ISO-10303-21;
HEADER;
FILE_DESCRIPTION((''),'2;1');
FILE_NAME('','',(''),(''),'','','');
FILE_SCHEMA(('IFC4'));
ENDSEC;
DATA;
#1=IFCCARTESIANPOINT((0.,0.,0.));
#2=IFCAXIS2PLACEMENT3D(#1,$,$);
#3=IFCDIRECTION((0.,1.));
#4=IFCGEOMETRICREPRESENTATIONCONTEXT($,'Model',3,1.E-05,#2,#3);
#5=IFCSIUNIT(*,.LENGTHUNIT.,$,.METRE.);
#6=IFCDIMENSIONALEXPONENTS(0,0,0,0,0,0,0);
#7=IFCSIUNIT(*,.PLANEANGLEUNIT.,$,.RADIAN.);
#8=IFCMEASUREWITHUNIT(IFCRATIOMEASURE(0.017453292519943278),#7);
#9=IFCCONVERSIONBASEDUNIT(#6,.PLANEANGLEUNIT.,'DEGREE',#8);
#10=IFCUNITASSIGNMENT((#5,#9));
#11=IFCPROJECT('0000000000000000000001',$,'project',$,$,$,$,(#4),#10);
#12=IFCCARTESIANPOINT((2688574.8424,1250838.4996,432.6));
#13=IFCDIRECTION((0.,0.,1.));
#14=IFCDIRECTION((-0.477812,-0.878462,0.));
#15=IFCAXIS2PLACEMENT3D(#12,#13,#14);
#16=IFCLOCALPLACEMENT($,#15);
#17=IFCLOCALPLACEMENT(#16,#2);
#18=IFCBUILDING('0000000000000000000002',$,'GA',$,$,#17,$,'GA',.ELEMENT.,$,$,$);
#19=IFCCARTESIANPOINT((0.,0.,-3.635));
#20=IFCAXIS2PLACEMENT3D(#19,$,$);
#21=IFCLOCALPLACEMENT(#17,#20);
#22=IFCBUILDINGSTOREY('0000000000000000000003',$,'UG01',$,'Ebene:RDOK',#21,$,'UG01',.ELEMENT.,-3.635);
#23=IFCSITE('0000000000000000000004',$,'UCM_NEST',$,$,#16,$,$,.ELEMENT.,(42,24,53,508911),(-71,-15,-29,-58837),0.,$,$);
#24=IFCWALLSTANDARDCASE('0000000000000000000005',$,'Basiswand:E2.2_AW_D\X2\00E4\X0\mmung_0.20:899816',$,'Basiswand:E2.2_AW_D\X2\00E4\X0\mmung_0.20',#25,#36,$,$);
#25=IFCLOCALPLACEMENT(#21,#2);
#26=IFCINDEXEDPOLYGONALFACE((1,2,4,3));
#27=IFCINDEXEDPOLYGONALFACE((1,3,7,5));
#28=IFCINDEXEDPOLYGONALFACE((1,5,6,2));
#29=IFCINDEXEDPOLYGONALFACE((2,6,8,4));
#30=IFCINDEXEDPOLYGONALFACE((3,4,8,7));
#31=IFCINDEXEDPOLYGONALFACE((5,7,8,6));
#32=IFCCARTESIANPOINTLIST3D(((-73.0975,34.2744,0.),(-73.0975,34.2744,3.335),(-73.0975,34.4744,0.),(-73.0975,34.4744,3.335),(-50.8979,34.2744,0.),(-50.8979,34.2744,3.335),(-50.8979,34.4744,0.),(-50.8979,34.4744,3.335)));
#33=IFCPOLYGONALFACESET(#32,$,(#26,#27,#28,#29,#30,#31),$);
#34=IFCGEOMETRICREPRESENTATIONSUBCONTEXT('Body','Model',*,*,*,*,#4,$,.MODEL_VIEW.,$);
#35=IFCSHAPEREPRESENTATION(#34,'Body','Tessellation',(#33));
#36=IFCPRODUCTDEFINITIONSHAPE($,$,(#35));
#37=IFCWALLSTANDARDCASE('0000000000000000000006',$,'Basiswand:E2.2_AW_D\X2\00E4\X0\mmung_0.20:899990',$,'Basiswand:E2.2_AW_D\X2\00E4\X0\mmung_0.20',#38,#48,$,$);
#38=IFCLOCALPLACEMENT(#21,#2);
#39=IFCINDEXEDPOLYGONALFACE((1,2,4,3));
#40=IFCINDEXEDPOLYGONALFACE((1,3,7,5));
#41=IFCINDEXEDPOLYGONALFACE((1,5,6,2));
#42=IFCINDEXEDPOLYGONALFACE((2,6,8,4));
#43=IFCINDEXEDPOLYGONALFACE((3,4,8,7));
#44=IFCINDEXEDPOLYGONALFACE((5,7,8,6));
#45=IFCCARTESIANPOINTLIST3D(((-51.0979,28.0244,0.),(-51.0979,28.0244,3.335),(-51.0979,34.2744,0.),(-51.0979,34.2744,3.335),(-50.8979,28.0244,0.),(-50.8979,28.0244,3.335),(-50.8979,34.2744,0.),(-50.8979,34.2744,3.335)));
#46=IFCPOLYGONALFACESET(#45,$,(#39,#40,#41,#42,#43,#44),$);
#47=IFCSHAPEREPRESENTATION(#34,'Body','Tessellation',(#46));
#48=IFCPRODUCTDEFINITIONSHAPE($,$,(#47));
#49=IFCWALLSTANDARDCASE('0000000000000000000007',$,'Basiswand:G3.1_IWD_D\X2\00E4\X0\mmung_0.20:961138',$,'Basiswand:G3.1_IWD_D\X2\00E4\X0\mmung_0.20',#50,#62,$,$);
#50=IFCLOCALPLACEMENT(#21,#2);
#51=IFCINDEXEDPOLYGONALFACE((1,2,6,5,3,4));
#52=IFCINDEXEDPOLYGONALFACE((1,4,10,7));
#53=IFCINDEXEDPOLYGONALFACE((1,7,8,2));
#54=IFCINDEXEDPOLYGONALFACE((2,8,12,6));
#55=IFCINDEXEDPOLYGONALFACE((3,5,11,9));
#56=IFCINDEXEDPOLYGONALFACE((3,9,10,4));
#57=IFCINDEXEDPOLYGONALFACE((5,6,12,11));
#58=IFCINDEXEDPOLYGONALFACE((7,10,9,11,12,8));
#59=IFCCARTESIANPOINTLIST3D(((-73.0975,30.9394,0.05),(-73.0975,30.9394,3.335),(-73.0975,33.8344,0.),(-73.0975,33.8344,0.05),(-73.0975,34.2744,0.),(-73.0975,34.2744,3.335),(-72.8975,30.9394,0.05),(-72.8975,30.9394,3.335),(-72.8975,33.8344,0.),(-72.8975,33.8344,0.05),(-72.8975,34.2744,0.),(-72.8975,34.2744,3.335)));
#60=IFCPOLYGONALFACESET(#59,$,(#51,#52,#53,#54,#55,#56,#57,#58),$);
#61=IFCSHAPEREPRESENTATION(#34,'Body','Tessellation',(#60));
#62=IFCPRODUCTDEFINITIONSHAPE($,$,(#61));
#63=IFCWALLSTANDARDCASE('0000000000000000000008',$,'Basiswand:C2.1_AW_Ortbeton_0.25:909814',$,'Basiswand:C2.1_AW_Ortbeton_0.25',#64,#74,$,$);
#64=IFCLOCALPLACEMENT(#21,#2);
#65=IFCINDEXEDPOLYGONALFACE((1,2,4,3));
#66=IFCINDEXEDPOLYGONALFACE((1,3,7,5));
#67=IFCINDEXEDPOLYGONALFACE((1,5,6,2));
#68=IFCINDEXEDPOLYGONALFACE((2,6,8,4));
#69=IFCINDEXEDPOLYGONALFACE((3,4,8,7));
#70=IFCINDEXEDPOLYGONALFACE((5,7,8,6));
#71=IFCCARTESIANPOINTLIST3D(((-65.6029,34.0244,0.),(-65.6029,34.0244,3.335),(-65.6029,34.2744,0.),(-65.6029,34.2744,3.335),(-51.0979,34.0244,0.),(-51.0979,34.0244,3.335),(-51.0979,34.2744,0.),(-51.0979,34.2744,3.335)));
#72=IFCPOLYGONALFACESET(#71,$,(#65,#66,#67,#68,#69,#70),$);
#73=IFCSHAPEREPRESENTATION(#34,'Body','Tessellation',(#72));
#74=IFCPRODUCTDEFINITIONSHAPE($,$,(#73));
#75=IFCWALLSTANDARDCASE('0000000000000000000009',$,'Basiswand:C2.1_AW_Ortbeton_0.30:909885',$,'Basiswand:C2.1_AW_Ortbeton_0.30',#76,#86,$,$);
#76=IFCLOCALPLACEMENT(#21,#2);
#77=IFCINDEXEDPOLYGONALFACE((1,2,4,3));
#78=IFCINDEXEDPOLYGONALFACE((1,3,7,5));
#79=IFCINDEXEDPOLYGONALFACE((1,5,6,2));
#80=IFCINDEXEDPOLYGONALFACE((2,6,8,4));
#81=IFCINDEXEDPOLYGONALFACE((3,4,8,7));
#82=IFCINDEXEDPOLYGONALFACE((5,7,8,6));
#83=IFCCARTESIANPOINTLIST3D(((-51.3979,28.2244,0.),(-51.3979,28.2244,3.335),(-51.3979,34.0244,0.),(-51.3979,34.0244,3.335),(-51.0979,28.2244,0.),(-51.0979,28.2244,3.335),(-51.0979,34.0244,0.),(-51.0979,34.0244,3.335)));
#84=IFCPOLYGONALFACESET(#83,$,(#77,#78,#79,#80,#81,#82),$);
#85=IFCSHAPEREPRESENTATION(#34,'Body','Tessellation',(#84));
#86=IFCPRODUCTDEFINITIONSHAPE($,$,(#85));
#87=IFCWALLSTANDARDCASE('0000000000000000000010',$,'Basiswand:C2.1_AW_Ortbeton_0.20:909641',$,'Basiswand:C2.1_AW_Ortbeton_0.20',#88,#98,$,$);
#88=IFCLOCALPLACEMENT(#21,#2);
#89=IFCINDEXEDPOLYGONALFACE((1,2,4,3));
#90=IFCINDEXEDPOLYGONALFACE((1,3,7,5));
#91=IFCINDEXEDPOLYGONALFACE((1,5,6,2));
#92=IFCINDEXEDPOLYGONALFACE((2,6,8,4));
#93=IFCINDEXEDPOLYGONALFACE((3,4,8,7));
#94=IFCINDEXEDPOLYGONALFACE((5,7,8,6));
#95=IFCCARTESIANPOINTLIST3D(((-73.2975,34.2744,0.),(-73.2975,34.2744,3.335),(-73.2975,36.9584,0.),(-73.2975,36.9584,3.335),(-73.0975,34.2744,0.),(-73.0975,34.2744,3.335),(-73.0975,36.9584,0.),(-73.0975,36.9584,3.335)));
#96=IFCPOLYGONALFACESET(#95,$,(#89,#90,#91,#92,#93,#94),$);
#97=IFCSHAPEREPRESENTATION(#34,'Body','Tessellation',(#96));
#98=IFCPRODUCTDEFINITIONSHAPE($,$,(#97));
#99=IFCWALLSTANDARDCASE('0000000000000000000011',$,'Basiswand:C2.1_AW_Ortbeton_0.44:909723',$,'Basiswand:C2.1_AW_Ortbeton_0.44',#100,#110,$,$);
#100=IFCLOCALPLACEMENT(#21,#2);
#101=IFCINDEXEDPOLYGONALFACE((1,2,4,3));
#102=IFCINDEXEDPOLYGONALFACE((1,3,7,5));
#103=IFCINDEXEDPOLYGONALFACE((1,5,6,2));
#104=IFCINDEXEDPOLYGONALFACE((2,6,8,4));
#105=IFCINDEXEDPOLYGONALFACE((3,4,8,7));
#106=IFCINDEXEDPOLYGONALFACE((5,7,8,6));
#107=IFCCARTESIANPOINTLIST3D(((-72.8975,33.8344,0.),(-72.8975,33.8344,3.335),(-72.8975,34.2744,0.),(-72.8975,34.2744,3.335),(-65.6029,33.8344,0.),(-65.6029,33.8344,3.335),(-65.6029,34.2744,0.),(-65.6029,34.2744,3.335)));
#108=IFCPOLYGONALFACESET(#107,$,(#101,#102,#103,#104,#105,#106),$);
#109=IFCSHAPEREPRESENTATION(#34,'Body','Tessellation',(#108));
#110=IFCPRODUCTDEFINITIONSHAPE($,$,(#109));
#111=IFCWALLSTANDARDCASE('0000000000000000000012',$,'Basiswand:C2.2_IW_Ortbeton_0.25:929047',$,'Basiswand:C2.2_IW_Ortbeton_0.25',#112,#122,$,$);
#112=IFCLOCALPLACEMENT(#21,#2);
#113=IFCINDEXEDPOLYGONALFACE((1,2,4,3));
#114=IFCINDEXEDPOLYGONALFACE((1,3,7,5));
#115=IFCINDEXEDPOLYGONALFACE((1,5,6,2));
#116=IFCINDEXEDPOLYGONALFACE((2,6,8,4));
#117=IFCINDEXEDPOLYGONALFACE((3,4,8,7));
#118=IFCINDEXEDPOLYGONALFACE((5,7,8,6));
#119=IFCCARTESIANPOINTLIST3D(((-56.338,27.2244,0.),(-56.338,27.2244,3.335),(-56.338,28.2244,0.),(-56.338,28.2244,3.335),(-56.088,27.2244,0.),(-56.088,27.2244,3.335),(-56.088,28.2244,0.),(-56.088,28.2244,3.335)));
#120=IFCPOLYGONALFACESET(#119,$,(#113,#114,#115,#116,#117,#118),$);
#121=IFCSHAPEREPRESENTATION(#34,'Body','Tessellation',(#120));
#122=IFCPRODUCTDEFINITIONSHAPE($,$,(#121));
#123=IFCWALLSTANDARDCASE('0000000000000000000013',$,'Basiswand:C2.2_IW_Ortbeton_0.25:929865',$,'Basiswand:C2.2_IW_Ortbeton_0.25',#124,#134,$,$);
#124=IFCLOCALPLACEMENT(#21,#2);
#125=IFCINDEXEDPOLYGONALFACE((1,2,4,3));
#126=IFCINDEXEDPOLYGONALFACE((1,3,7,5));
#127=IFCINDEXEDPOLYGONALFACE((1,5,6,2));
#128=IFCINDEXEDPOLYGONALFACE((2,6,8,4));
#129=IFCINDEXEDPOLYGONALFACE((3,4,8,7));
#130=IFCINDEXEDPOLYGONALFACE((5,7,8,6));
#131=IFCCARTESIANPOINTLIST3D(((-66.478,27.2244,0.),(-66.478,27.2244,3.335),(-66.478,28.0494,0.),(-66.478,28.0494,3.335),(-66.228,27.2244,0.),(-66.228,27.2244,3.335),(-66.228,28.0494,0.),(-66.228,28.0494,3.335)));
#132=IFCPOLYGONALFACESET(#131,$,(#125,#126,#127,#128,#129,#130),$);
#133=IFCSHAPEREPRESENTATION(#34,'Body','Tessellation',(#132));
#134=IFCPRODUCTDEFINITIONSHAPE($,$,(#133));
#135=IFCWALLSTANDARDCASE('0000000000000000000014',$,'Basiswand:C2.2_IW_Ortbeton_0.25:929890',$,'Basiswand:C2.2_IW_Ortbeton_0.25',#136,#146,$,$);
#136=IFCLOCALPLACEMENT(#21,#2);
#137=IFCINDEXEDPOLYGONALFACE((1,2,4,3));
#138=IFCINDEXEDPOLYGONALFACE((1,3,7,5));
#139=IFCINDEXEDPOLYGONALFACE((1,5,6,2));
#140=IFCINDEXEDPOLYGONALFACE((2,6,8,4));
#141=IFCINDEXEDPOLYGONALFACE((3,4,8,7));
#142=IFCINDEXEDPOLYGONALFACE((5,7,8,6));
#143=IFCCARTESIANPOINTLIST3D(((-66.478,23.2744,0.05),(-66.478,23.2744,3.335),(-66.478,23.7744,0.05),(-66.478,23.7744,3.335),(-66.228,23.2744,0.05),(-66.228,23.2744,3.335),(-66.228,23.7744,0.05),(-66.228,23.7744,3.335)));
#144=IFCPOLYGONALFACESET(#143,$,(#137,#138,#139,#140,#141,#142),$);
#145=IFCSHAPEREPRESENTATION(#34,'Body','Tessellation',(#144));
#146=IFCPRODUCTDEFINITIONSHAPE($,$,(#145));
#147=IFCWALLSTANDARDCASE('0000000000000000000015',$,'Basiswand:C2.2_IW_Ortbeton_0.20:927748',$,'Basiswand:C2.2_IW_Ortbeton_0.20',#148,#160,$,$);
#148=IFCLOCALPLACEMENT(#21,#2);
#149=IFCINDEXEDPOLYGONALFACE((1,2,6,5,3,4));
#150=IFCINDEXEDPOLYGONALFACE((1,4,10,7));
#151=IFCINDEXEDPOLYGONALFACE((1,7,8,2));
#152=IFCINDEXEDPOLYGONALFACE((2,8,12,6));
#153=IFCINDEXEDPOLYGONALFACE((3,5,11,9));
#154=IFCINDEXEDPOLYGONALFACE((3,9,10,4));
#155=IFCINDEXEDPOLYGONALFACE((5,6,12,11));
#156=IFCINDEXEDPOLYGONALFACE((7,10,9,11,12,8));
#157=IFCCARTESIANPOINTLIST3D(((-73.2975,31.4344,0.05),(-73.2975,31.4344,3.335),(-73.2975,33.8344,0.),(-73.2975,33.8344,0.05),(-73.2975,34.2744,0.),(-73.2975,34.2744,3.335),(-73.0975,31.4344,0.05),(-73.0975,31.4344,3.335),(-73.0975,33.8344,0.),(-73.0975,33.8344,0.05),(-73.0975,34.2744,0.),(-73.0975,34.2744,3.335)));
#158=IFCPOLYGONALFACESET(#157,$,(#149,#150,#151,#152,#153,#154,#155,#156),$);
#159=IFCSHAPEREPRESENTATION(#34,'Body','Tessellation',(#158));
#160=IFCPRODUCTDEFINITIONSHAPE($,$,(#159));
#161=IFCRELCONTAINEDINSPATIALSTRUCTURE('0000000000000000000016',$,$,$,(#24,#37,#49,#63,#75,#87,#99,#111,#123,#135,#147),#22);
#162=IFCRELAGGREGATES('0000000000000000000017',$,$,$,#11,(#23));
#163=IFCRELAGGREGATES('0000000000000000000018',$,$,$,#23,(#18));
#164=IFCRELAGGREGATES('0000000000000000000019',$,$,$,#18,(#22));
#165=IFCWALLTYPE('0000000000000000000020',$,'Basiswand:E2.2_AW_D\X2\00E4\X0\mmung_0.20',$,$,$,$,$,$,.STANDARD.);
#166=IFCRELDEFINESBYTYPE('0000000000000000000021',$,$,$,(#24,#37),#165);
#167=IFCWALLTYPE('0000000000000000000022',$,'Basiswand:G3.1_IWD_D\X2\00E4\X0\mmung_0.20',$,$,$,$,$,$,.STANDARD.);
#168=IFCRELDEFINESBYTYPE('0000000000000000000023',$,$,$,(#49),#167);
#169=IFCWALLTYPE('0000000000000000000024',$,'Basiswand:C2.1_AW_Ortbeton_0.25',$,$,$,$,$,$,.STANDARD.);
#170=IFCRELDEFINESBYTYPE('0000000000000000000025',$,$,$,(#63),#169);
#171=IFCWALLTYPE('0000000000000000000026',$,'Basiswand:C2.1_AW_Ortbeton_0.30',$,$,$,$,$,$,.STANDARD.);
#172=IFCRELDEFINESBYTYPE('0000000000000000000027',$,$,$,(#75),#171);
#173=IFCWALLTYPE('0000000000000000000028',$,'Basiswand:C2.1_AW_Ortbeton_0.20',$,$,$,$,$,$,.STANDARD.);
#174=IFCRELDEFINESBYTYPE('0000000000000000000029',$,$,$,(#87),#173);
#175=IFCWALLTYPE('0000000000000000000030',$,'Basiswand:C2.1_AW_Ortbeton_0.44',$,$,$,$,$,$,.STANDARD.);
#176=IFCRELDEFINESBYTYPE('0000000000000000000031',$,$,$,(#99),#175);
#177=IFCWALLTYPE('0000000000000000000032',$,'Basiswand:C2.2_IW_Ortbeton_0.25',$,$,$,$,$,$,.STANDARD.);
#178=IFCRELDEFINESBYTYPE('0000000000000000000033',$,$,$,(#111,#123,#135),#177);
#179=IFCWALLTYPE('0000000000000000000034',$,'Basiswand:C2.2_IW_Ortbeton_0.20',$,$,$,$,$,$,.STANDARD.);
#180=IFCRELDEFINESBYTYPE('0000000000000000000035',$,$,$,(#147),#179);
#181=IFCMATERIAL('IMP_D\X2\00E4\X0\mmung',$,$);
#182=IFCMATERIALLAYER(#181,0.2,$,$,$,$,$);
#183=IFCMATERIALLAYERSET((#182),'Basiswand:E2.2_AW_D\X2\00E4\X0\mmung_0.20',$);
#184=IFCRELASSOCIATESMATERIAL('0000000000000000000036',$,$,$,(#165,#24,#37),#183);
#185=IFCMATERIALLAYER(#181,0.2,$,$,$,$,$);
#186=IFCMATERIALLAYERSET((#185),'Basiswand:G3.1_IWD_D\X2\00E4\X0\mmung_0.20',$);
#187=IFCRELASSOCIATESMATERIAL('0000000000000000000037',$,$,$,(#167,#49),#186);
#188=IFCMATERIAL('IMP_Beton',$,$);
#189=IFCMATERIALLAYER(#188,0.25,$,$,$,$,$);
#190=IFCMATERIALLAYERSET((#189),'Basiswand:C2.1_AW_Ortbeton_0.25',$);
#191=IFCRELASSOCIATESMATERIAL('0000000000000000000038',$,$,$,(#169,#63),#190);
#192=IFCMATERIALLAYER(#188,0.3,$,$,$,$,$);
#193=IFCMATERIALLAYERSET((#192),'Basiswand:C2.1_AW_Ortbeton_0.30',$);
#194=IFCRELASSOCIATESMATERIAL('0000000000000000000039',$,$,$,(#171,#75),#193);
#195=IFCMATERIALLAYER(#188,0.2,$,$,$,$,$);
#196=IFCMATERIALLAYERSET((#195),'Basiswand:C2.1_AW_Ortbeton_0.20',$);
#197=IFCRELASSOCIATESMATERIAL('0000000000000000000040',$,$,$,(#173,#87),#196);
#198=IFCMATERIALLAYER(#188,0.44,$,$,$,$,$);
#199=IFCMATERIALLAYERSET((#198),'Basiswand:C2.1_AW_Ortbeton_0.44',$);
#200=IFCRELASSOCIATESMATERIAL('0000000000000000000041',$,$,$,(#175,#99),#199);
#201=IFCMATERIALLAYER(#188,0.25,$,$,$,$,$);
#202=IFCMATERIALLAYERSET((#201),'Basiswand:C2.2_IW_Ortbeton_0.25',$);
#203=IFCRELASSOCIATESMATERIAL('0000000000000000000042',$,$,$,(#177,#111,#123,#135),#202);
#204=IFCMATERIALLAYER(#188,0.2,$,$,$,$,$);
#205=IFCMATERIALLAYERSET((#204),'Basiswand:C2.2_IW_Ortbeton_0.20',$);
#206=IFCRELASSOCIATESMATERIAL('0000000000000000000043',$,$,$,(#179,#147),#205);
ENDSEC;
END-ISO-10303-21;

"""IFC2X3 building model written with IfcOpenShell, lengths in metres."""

from ifc_helpers import new_model, entity, si_unit, converted_unit, direction, frame, frame_2d, origin, place, context, subcontext, project, spatial, polyline, rectangle, extrude, clip, bounded_halfspace, material, layer, layer_set, layer_usage, type_object, element, save


model = new_model("IFC2X3")

# Units and contexts
model_context = context("Model", 3, precision=1e-05, world=origin(), true_north=direction((0.0, 1.0)))
body_context = subcontext(model_context, "Body", "Model", "MODEL_VIEW")
ifc_project = project(units=[si_unit("LENGTHUNIT", "METRE"), converted_unit("PLANEANGLEUNIT", "DEGREE", entity("IfcRatioMeasure", 0.017453292519943278), si_unit("PLANEANGLEUNIT", "RADIAN"), dimensions=[0, 0, 0, 0, 0, 0, 0])], contexts=[model_context])

# Site, building, storey
site_placement = place(None, frame((2688574.8424, 1250838.4996, 432.6), z_axis=(0.0, 0.0, 1.0), x_axis=(-0.477812, -0.878462, 0.0)))
site = spatial("IfcSite", under=ifc_project, at=site_placement, Name="UCM_NEST", CompositionType="ELEMENT", RefLatitude=(42, 24, 53, 508911), RefLongitude=(-71, -15, -29, -58837), RefElevation=0.0)
building_placement = place(site_placement, origin())
building = spatial("IfcBuilding", under=site, at=building_placement, Name="GA", LongName="GA", CompositionType="ELEMENT")
storey_placement = place(building_placement, frame((0.0, 0.0, -3.635)))
storey = spatial("IfcBuildingStorey", under=building, at=storey_placement, Name="UG01", ObjectType="Ebene:RDOK", LongName="UG01", CompositionType="ELEMENT", Elevation=-3.635)

# Walls
ifc_material_1 = material(Name="IMP_Dämmung")
ifc_layer_1 = layer(ifc_material_1, 0.2)
ifc_layer_set_1 = layer_set([ifc_layer_1], Name="Basiswand:E2.2_AW_Dämmung_0.20")
ifc_layer_usage_1 = layer_usage(ifc_layer_set_1, "AXIS2", "NEGATIVE", 0.1)
wall_type_1 = type_object("IfcWallType", Name="Basiswand:E2.2_AW_Dämmung_0.20", PredefinedType="STANDARD", material=ifc_layer_set_1)
wall_1_placement = place(storey_placement, frame((-73.0975, 34.3744, 0.0)))
element("IfcWallStandardCase", 1, at=wall_1_placement, inside=storey, type_object=wall_type_1, material=ifc_layer_usage_1, Name="Basiswand:E2.2_AW_Dämmung_0.20:899816", ObjectType="Basiswand:E2.2_AW_Dämmung_0.20", context=body_context, shape_type="SweptSolid", body=[
    extrude(rectangle(XDim=22.1995, YDim=0.2, at=frame_2d((11.0998, 0.0), x_axis=(-1.0, 0.0))), origin(), (0.0, 0.0, 1.0), 3.335),
])
wall_2_placement = place(storey_placement, frame((-50.9979, 34.2744, 0.0), z_axis=(0.0, 0.0, 1.0), x_axis=(0.0, -1.0, 0.0)))
element("IfcWallStandardCase", 2, at=wall_2_placement, inside=storey, type_object=wall_type_1, material=ifc_layer_usage_1, Name="Basiswand:E2.2_AW_Dämmung_0.20:899990", ObjectType="Basiswand:E2.2_AW_Dämmung_0.20", context=body_context, shape_type="SweptSolid", body=[
    extrude(rectangle(XDim=6.25, YDim=0.2, at=frame_2d((3.125, 0.0), x_axis=(-1.0, 0.0))), origin(), (0.0, 0.0, 1.0), 3.335),
])
ifc_layer_2 = layer(ifc_material_1, 0.2)
ifc_layer_set_2 = layer_set([ifc_layer_2], Name="Basiswand:G3.1_IWD_Dämmung_0.20")
ifc_layer_usage_2 = layer_usage(ifc_layer_set_2, "AXIS2", "NEGATIVE", 0.1)
wall_type_2 = type_object("IfcWallType", Name="Basiswand:G3.1_IWD_Dämmung_0.20", PredefinedType="STANDARD", material=ifc_layer_set_2)
wall_3_placement = place(storey_placement, frame((-72.9975, 34.2744, 0.0), z_axis=(0.0, 0.0, 1.0), x_axis=(0.0, -1.0, 0.0)))
element("IfcWallStandardCase", 3, at=wall_3_placement, inside=storey, type_object=wall_type_2, material=ifc_layer_usage_2, Name="Basiswand:G3.1_IWD_Dämmung_0.20:961138", ObjectType="Basiswand:G3.1_IWD_Dämmung_0.20", context=body_context, shape_type="Clipping", body=[
    clip(clip(extrude(rectangle(XDim=3.335, YDim=0.2, at=frame_2d((1.6675, 0.0), x_axis=(-1.0, 0.0))), origin(), (0.0, 0.0, 1.0), 3.335), bounded_halfspace(frame((0.44, -0.1, 0.05), z_axis=(0.0, 0.0, 1.0), x_axis=(-1.0, 0.0, 0.0)), True, frame((0.44, -0.1, 0.05), z_axis=(0.0, 0.0, 1.0), x_axis=(-1.0, 0.0, 0.0)), polyline([(0.0, 0.0), (-2.895, 0.0), (-2.895, -0.2), (0.0, -0.2), (0.0, 0.0)]))), bounded_halfspace(frame((0.44, 0.1, 0.05), z_axis=(-1.0, 0.0, 0.0), x_axis=(0.0, 0.0, 1.0)), True, frame((0.44, 0.1, 0.05), z_axis=(-1.0, 0.0, 0.0), x_axis=(0.0, 0.0, 1.0)), polyline([(0.0, 0.0), (-0.05, 0.0), (-0.05, -0.2), (0.0, -0.2), (0.0, 0.0)]))),
])
ifc_material_2 = material(Name="IMP_Beton")
ifc_layer_3 = layer(ifc_material_2, 0.25)
ifc_layer_set_3 = layer_set([ifc_layer_3], Name="Basiswand:C2.1_AW_Ortbeton_0.25")
ifc_layer_usage_3 = layer_usage(ifc_layer_set_3, "AXIS2", "NEGATIVE", 0.125)
wall_type_3 = type_object("IfcWallType", Name="Basiswand:C2.1_AW_Ortbeton_0.25", PredefinedType="STANDARD", material=ifc_layer_set_3)
wall_4_placement = place(storey_placement, frame((-65.6029, 34.1494, 0.0)))
element("IfcWallStandardCase", 4, at=wall_4_placement, inside=storey, type_object=wall_type_3, material=ifc_layer_usage_3, Name="Basiswand:C2.1_AW_Ortbeton_0.25:909814", ObjectType="Basiswand:C2.1_AW_Ortbeton_0.25", context=body_context, shape_type="SweptSolid", body=[
    extrude(rectangle(XDim=14.505, YDim=0.25, at=frame_2d((7.2525, 0.0), x_axis=(-1.0, 0.0))), origin(), (0.0, 0.0, 1.0), 3.335),
])
ifc_layer_4 = layer(ifc_material_2, 0.3)
ifc_layer_set_4 = layer_set([ifc_layer_4], Name="Basiswand:C2.1_AW_Ortbeton_0.30")
ifc_layer_usage_4 = layer_usage(ifc_layer_set_4, "AXIS2", "NEGATIVE", 0.15)
wall_type_4 = type_object("IfcWallType", Name="Basiswand:C2.1_AW_Ortbeton_0.30", PredefinedType="STANDARD", material=ifc_layer_set_4)
wall_5_placement = place(storey_placement, frame((-51.2479, 34.0244, 0.0), z_axis=(0.0, 0.0, 1.0), x_axis=(0.0, -1.0, 0.0)))
element("IfcWallStandardCase", 5, at=wall_5_placement, inside=storey, type_object=wall_type_4, material=ifc_layer_usage_4, Name="Basiswand:C2.1_AW_Ortbeton_0.30:909885", ObjectType="Basiswand:C2.1_AW_Ortbeton_0.30", context=body_context, shape_type="SweptSolid", body=[
    extrude(rectangle(XDim=5.8, YDim=0.3, at=frame_2d((2.9, 0.0), x_axis=(-1.0, 0.0))), origin(), (0.0, 0.0, 1.0), 3.335),
])
ifc_layer_5 = layer(ifc_material_2, 0.2)
ifc_layer_set_5 = layer_set([ifc_layer_5], Name="Basiswand:C2.1_AW_Ortbeton_0.20")
ifc_layer_usage_5 = layer_usage(ifc_layer_set_5, "AXIS2", "NEGATIVE", 0.1)
wall_type_5 = type_object("IfcWallType", Name="Basiswand:C2.1_AW_Ortbeton_0.20", PredefinedType="STANDARD", material=ifc_layer_set_5)
wall_6_placement = place(storey_placement, frame((-73.1975, 36.9584, 0.0), z_axis=(0.0, 0.0, 1.0), x_axis=(0.0, -1.0, 0.0)))
element("IfcWallStandardCase", 6, at=wall_6_placement, inside=storey, type_object=wall_type_5, material=ifc_layer_usage_5, Name="Basiswand:C2.1_AW_Ortbeton_0.20:909641", ObjectType="Basiswand:C2.1_AW_Ortbeton_0.20", context=body_context, shape_type="SweptSolid", body=[
    extrude(rectangle(XDim=2.684, YDim=0.2, at=frame_2d((1.342, 0.0), x_axis=(-1.0, 0.0))), origin(), (0.0, 0.0, 1.0), 3.335),
])
ifc_layer_6 = layer(ifc_material_2, 0.44)
ifc_layer_set_6 = layer_set([ifc_layer_6], Name="Basiswand:C2.1_AW_Ortbeton_0.44")
ifc_layer_usage_6 = layer_usage(ifc_layer_set_6, "AXIS2", "NEGATIVE", 0.22)
wall_type_6 = type_object("IfcWallType", Name="Basiswand:C2.1_AW_Ortbeton_0.44", PredefinedType="STANDARD", material=ifc_layer_set_6)
wall_7_placement = place(storey_placement, frame((-72.8975, 34.0544, 0.0)))
element("IfcWallStandardCase", 7, at=wall_7_placement, inside=storey, type_object=wall_type_6, material=ifc_layer_usage_6, Name="Basiswand:C2.1_AW_Ortbeton_0.44:909723", ObjectType="Basiswand:C2.1_AW_Ortbeton_0.44", context=body_context, shape_type="SweptSolid", body=[
    extrude(rectangle(XDim=7.2946, YDim=0.44, at=frame_2d((3.6473, 0.0), x_axis=(-1.0, 0.0))), origin(), (0.0, 0.0, 1.0), 3.335),
])
ifc_layer_7 = layer(ifc_material_2, 0.25)
ifc_layer_set_7 = layer_set([ifc_layer_7], Name="Basiswand:C2.2_IW_Ortbeton_0.25")
ifc_layer_usage_7 = layer_usage(ifc_layer_set_7, "AXIS2", "NEGATIVE", 0.125)
wall_type_7 = type_object("IfcWallType", Name="Basiswand:C2.2_IW_Ortbeton_0.25", PredefinedType="STANDARD", material=ifc_layer_set_7)
wall_8_placement = place(storey_placement, frame((-56.213, 28.2244, 0.0), z_axis=(0.0, 0.0, 1.0), x_axis=(0.0, -1.0, 0.0)))
element("IfcWallStandardCase", 8, at=wall_8_placement, inside=storey, type_object=wall_type_7, material=ifc_layer_usage_7, Name="Basiswand:C2.2_IW_Ortbeton_0.25:929047", ObjectType="Basiswand:C2.2_IW_Ortbeton_0.25", context=body_context, shape_type="SweptSolid", body=[
    extrude(rectangle(XDim=1.0, YDim=0.25, at=frame_2d((0.5, 0.0), x_axis=(-1.0, 0.0))), origin(), (0.0, 0.0, 1.0), 3.335),
])
wall_9_placement = place(storey_placement, frame((-66.353, 28.0494, 0.0), z_axis=(0.0, 0.0, 1.0), x_axis=(0.0, -1.0, 0.0)))
element("IfcWallStandardCase", 9, at=wall_9_placement, inside=storey, type_object=wall_type_7, material=ifc_layer_usage_7, Name="Basiswand:C2.2_IW_Ortbeton_0.25:929865", ObjectType="Basiswand:C2.2_IW_Ortbeton_0.25", context=body_context, shape_type="SweptSolid", body=[
    extrude(rectangle(XDim=0.825, YDim=0.25, at=frame_2d((0.4125, 0.0), x_axis=(-1.0, 0.0))), origin(), (0.0, 0.0, 1.0), 3.335),
])
wall_10_placement = place(storey_placement, frame((-66.353, 23.7744, 0.05), z_axis=(0.0, 0.0, 1.0), x_axis=(0.0, -1.0, 0.0)))
element("IfcWallStandardCase", 10, at=wall_10_placement, inside=storey, type_object=wall_type_7, material=ifc_layer_usage_7, Name="Basiswand:C2.2_IW_Ortbeton_0.25:929890", ObjectType="Basiswand:C2.2_IW_Ortbeton_0.25", context=body_context, shape_type="Clipping", body=[
    clip(extrude(rectangle(XDim=0.5, YDim=0.25, at=frame_2d((0.25, 0.0), x_axis=(-1.0, 0.0))), origin(), (0.0, 0.0, 1.0), 3.285), bounded_halfspace(frame((0.5, -0.125, 0.0), z_axis=(0.0, 0.0, 1.0), x_axis=(-1.0, 0.0, 0.0)), True, frame((0.5, -0.125, 0.0), z_axis=(0.0, 0.0, 1.0), x_axis=(-1.0, 0.0, 0.0)), polyline([(0.0, 0.0), (0.0, -0.25), (0.5, -0.25), (0.5, 0.0), (0.0, 0.0)]))),
])
ifc_layer_8 = layer(ifc_material_2, 0.2)
ifc_layer_set_8 = layer_set([ifc_layer_8], Name="Basiswand:C2.2_IW_Ortbeton_0.20")
ifc_layer_usage_8 = layer_usage(ifc_layer_set_8, "AXIS2", "NEGATIVE", 0.1)
wall_type_8 = type_object("IfcWallType", Name="Basiswand:C2.2_IW_Ortbeton_0.20", PredefinedType="STANDARD", material=ifc_layer_set_8)
wall_11_placement = place(storey_placement, frame((-73.1975, 34.2744, 0.0), z_axis=(0.0, 0.0, 1.0), x_axis=(0.0, -1.0, 0.0)))
element("IfcWallStandardCase", 11, at=wall_11_placement, inside=storey, type_object=wall_type_8, material=ifc_layer_usage_8, Name="Basiswand:C2.2_IW_Ortbeton_0.20:927748", ObjectType="Basiswand:C2.2_IW_Ortbeton_0.20", context=body_context, shape_type="Clipping", body=[
    clip(clip(extrude(rectangle(XDim=2.84, YDim=0.2, at=frame_2d((1.42, 0.0), x_axis=(-1.0, 0.0))), origin(), (0.0, 0.0, 1.0), 3.335), bounded_halfspace(frame((0.44, -0.1, 0.05), z_axis=(0.0, 0.0, 1.0), x_axis=(-1.0, 0.0, 0.0)), True, frame((0.44, -0.1, 0.05), z_axis=(0.0, 0.0, 1.0), x_axis=(-1.0, 0.0, 0.0)), polyline([(0.0, 0.0), (-2.4, 0.0), (-2.4, -0.2), (0.0, -0.2), (0.0, 0.0)]))), bounded_halfspace(frame((0.44, 0.1, 0.05), z_axis=(-1.0, 0.0, 0.0), x_axis=(0.0, 0.0, 1.0)), True, frame((0.44, 0.1, 0.05), z_axis=(-1.0, 0.0, 0.0), x_axis=(0.0, 0.0, 1.0)), polyline([(0.0, 0.0), (-0.05, 0.0), (-0.05, -0.2), (0.0, -0.2), (0.0, 0.0)]))),
])

save(model, "model.ifc")
